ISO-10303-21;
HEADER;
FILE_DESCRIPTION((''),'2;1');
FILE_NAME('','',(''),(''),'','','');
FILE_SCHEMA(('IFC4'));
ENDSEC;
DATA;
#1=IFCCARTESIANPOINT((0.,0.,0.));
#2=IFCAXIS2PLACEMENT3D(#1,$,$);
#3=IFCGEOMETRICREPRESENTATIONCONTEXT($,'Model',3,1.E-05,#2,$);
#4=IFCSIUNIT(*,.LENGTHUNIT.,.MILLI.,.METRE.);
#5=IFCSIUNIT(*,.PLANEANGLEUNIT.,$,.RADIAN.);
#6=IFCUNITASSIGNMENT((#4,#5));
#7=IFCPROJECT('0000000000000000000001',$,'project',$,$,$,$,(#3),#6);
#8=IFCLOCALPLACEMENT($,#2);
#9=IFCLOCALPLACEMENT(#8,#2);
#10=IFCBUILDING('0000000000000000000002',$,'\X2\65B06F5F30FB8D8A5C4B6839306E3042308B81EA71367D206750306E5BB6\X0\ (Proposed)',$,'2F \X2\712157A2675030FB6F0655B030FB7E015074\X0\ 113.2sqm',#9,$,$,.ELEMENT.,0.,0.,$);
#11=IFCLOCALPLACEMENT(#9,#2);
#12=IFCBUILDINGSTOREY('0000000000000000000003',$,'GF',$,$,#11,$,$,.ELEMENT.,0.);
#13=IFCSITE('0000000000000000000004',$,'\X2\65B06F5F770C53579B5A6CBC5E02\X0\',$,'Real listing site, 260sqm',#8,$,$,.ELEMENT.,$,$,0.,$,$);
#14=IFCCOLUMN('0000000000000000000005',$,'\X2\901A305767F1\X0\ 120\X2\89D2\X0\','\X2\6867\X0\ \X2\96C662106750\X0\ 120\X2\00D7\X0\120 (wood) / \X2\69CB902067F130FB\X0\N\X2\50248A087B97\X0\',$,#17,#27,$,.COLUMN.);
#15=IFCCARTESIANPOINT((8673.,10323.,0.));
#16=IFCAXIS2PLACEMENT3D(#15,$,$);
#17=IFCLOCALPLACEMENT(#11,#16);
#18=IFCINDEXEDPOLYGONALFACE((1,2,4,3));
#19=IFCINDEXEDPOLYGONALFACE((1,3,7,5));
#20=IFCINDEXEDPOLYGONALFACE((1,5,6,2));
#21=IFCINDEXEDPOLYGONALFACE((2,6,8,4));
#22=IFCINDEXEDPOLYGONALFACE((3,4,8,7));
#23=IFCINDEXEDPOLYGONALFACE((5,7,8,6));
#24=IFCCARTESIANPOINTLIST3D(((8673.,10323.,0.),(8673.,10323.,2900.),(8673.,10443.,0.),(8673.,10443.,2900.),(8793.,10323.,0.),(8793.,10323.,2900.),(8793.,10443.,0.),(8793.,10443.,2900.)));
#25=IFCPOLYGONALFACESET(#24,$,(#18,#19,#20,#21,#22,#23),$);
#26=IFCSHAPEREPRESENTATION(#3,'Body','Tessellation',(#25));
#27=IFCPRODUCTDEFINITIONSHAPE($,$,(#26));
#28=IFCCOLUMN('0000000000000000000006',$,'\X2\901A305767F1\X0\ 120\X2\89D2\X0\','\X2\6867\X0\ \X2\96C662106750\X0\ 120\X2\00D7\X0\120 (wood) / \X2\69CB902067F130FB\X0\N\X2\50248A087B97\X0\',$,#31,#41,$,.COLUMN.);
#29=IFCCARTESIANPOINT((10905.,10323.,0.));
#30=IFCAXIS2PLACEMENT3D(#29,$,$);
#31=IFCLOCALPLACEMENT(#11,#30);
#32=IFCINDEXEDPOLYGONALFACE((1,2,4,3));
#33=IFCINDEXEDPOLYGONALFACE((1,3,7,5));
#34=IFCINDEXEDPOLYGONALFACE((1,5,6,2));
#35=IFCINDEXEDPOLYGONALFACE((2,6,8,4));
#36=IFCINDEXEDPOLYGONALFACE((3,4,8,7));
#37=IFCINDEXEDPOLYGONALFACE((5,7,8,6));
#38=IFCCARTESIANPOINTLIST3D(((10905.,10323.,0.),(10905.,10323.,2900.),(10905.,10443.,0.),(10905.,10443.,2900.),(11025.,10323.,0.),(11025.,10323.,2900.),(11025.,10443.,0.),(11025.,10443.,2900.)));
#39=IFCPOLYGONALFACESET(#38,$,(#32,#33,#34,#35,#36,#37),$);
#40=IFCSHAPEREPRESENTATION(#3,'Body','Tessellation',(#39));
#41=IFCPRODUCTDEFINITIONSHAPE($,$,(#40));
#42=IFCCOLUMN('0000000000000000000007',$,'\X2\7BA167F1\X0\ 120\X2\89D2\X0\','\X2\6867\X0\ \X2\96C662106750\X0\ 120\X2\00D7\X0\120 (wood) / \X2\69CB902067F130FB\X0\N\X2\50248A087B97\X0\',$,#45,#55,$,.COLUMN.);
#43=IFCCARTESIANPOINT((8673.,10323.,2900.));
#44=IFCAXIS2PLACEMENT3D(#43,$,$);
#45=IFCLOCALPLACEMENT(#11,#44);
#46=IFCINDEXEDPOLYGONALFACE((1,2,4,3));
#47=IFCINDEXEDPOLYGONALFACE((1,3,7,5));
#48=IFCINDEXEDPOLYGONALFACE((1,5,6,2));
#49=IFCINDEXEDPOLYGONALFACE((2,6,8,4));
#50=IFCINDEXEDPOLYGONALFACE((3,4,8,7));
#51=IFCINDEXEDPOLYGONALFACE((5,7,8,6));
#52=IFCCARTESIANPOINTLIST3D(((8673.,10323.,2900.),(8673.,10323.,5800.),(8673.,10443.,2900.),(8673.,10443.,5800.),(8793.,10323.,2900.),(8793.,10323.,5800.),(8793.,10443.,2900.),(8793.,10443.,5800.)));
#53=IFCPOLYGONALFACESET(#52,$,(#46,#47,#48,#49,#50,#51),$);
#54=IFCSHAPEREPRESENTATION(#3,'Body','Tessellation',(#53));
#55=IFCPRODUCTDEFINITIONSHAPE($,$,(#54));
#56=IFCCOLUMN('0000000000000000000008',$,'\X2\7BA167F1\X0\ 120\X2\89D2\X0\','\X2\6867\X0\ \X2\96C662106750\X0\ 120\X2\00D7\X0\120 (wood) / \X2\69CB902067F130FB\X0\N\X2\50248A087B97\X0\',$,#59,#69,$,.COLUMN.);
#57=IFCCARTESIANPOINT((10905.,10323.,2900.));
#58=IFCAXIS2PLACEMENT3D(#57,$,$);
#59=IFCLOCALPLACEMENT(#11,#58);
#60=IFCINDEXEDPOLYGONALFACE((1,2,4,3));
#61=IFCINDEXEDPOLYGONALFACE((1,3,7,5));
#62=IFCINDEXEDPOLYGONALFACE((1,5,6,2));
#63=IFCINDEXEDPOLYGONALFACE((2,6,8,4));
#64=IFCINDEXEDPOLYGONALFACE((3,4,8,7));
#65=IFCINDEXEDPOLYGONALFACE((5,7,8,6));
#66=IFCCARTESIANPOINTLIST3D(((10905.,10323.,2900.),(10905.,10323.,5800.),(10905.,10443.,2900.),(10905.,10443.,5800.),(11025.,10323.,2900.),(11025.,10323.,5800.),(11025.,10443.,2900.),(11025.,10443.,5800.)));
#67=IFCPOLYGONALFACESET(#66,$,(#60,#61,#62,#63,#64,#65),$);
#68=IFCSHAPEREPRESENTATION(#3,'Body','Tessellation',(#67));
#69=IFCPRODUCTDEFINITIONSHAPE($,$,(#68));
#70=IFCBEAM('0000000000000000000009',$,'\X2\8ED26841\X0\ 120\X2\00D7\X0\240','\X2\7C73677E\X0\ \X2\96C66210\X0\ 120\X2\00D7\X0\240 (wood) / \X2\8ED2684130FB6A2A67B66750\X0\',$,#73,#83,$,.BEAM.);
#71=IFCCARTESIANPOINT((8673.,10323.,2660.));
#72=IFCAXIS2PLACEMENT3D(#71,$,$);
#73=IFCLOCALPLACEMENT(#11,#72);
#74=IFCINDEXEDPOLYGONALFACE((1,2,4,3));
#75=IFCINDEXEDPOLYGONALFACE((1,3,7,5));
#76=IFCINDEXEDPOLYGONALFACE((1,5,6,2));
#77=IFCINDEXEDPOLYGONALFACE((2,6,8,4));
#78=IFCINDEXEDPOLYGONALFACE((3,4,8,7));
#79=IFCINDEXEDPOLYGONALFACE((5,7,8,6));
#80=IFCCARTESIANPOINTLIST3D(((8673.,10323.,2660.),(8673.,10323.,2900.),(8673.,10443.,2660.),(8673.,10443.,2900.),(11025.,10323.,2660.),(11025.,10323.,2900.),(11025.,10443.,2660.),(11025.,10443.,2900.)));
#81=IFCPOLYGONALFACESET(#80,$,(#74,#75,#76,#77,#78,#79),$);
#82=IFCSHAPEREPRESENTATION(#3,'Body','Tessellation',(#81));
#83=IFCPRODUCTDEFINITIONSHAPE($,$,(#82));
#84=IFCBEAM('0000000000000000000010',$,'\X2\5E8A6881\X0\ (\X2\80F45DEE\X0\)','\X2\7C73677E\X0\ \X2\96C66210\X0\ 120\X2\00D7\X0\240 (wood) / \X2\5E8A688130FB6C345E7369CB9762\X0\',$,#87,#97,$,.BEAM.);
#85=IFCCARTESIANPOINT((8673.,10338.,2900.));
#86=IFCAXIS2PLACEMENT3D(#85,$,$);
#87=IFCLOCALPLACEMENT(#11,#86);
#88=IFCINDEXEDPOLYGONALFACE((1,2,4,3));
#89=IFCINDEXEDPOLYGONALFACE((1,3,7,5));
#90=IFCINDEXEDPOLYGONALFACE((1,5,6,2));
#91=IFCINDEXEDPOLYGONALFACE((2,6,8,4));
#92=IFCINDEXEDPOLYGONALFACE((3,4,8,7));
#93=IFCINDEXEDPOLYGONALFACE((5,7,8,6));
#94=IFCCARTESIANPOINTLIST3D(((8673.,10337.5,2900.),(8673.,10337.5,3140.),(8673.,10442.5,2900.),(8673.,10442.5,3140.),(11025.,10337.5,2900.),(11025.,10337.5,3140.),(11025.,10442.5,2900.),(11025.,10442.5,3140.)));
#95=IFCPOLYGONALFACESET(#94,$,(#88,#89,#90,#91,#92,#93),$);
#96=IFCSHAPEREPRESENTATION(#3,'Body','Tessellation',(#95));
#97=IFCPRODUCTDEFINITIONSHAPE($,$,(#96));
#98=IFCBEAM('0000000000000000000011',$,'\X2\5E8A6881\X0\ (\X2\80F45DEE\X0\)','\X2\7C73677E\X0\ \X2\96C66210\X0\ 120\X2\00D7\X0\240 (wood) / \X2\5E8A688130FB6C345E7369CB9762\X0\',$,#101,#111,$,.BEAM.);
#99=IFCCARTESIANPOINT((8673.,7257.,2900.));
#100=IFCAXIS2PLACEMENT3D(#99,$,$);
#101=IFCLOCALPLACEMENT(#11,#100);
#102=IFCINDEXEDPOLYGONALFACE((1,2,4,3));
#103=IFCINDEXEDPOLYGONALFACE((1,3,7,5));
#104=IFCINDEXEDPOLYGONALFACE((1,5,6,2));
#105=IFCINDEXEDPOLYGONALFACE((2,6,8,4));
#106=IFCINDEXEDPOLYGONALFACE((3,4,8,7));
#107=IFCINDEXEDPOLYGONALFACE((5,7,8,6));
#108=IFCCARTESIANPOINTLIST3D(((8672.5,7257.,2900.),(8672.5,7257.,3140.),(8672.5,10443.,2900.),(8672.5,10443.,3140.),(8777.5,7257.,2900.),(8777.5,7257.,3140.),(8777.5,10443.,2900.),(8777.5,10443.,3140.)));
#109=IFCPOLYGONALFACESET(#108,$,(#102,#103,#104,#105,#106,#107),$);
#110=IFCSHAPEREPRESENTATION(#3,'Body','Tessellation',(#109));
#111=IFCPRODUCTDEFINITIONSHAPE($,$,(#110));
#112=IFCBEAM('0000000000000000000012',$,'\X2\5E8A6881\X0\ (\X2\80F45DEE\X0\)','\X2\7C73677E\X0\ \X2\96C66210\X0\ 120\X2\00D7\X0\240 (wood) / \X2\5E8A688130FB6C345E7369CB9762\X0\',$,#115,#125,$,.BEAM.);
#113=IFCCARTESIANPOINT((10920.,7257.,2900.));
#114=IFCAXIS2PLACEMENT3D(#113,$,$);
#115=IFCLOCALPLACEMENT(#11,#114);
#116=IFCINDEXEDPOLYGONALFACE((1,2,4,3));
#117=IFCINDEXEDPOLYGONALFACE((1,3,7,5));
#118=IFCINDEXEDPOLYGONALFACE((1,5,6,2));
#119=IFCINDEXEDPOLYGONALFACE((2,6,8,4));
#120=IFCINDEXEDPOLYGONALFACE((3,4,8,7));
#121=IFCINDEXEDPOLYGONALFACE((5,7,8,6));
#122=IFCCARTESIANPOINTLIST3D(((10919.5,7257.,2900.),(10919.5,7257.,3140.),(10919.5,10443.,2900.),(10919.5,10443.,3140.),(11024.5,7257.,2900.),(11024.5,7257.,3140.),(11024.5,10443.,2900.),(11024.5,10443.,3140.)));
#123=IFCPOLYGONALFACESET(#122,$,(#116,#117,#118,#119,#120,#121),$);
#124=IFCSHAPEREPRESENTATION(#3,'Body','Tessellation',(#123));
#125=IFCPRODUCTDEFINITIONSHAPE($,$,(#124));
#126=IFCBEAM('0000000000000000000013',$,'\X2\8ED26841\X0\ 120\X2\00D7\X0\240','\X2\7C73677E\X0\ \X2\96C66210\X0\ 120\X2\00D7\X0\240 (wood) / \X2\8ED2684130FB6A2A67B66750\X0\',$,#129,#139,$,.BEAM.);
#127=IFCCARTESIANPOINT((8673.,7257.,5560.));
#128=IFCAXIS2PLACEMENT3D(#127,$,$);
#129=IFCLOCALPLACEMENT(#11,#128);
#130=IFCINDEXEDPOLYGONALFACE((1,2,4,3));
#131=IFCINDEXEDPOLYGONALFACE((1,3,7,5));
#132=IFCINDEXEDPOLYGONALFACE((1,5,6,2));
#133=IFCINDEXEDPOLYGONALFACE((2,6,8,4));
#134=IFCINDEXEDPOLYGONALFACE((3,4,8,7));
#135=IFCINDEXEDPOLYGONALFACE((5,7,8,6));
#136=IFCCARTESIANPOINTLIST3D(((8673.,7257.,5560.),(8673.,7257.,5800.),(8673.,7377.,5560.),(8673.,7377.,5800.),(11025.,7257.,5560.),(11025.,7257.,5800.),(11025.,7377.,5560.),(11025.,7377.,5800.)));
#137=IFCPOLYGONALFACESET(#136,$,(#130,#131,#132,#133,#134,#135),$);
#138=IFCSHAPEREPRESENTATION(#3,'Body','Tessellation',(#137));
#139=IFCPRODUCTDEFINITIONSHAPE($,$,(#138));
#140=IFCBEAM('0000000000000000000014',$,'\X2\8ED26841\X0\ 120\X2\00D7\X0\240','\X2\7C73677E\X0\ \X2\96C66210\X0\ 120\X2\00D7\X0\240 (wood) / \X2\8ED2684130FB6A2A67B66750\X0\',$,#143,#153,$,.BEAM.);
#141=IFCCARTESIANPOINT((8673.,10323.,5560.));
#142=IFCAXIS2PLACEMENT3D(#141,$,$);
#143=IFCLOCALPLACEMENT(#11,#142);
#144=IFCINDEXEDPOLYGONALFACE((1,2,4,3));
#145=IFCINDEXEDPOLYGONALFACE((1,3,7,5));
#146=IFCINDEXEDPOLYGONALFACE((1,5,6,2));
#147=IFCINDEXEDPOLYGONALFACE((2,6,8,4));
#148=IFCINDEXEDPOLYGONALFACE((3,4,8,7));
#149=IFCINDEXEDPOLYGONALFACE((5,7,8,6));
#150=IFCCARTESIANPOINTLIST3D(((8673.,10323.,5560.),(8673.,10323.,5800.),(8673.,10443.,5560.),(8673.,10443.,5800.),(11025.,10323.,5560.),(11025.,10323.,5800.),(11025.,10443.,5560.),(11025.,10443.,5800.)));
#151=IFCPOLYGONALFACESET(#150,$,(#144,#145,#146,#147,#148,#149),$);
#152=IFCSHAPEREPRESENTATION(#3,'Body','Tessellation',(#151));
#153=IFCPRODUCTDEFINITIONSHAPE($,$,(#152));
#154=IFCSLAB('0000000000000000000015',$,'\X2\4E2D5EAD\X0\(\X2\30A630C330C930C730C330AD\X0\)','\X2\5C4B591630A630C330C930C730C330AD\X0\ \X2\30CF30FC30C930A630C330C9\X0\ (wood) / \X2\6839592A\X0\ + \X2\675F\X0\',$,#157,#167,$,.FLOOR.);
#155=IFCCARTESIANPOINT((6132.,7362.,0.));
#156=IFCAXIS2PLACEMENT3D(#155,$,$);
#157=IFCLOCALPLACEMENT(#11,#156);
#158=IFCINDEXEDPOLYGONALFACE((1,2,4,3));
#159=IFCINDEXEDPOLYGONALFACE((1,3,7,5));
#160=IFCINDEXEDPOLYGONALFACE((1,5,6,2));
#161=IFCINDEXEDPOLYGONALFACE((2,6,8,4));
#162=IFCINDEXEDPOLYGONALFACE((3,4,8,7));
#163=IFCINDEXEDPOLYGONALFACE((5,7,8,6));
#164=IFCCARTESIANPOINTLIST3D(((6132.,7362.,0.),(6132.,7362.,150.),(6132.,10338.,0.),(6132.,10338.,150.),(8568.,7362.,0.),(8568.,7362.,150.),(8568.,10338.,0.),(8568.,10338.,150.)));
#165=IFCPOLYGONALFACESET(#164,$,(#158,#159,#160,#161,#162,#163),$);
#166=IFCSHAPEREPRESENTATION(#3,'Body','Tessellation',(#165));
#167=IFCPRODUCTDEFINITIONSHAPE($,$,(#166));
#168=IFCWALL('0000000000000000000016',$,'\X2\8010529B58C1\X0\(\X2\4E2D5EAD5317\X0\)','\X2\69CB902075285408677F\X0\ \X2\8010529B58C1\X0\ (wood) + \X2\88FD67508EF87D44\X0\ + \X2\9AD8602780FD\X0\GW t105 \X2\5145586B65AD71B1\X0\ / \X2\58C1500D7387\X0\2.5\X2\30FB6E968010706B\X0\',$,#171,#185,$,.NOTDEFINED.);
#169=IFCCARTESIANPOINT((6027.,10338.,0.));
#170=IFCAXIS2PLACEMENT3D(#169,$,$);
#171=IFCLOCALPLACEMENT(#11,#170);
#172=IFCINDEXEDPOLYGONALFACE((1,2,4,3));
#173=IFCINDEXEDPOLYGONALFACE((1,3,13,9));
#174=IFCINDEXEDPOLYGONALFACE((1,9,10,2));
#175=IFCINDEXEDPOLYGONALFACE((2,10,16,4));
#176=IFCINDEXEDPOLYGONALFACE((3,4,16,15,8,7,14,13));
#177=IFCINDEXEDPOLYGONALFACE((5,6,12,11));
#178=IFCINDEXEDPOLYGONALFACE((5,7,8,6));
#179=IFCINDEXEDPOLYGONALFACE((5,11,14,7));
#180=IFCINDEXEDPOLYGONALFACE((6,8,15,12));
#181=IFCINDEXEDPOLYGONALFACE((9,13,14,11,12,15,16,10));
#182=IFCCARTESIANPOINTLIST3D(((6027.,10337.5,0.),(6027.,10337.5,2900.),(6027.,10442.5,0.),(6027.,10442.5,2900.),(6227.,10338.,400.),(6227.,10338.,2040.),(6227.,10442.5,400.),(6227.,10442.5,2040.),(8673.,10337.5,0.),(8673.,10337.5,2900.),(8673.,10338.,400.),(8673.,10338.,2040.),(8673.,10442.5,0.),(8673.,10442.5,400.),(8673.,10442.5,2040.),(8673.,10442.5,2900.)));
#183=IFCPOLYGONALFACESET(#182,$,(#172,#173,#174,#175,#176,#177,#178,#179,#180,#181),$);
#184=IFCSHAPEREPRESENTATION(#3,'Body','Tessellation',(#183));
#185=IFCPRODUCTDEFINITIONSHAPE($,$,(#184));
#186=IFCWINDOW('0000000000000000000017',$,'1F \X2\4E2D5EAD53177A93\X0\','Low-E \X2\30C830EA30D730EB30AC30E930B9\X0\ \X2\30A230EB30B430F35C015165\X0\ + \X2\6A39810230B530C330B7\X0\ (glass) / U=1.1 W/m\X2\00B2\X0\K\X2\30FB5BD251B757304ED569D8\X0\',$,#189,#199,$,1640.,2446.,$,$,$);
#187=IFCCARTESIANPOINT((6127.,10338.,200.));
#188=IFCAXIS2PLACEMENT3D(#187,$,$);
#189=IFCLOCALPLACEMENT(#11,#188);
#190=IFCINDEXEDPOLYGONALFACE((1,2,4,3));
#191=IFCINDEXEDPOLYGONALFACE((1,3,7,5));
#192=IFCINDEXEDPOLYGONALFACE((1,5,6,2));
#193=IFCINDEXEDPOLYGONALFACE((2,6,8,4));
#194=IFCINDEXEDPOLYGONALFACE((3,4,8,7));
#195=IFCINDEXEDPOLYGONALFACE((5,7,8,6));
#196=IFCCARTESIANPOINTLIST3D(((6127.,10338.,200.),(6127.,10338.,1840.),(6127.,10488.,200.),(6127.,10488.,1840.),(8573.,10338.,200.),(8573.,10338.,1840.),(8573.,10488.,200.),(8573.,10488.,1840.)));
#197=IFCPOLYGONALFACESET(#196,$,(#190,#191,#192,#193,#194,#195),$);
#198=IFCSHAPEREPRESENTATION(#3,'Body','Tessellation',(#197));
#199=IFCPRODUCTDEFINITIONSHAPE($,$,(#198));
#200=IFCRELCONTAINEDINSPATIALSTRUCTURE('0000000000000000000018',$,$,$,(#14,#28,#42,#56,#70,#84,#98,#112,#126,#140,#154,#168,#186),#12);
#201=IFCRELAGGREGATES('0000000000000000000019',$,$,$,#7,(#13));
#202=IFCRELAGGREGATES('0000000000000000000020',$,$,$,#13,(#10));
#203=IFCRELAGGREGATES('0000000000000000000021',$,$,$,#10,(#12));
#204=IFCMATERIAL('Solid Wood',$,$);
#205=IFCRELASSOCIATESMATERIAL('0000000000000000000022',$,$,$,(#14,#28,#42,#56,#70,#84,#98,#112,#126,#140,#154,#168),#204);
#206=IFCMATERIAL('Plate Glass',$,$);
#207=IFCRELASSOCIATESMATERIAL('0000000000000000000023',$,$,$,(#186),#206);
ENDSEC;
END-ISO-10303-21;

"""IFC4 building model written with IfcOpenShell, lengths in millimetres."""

from ifc_helpers import new_model, si_unit, frame, frame_2d, origin, place, context, project, spatial, rectangle, extrude, material, element, fill, save


model = new_model("IFC4")

# Units and contexts
model_context = context("Model", 3, precision=1e-05, world=origin())
ifc_project = project(units=[si_unit("LENGTHUNIT", "METRE", prefix="MILLI"), si_unit("PLANEANGLEUNIT", "RADIAN")], contexts=[model_context])

# Site, building, storey
site_placement = place(None, origin())
site = spatial("IfcSite", under=ifc_project, at=site_placement, Name="新潟県南魚沼市", ObjectType="Real listing site, 260sqm", CompositionType="ELEMENT", RefElevation=0.0)
building_placement = place(site_placement, origin())
building = spatial("IfcBuilding", under=site, at=building_placement, Name="新潟・越屋根のある自然素材の家 (Proposed)", ObjectType="2F 無垢材・漆喰・縁側 113.2sqm", CompositionType="ELEMENT", ElevationOfRefHeight=0.0, ElevationOfTerrain=0.0)
storey_placement = place(building_placement, origin())
storey = spatial("IfcBuildingStorey", under=building, at=storey_placement, Name="GF", CompositionType="ELEMENT", Elevation=0.0)

# Columns
ifc_material_1 = material(Name="Solid Wood")
column_1_placement = place(storey_placement, frame((8673.0, 10323.0, 0.0)))
element("IfcColumn", 1, at=column_1_placement, inside=storey, material=ifc_material_1, Name="通し柱 120角", Description="桧 集成材 120×120 (wood) / 構造柱・N値計算", PredefinedType="COLUMN", context=model_context, shape_type="SweptSolid", body=[
    extrude(rectangle(XDim=120.0, YDim=120.0, at=frame_2d((60.0, 60.0))), frame((8673.0, 10323.0, 0.0)), (0.0, 0.0, 1.0), 2900.0),
])
column_2_placement = place(storey_placement, frame((10905.0, 10323.0, 0.0)))
element("IfcColumn", 2, at=column_2_placement, inside=storey, material=ifc_material_1, Name="通し柱 120角", Description="桧 集成材 120×120 (wood) / 構造柱・N値計算", PredefinedType="COLUMN", context=model_context, shape_type="SweptSolid", body=[
    extrude(rectangle(XDim=120.0, YDim=120.0, at=frame_2d((60.0, 60.0))), frame((10905.0, 10323.0, 0.0)), (0.0, 0.0, 1.0), 2900.0),
])
column_3_placement = place(storey_placement, frame((8673.0, 10323.0, 2900.0)))
element("IfcColumn", 3, at=column_3_placement, inside=storey, material=ifc_material_1, Name="管柱 120角", Description="桧 集成材 120×120 (wood) / 構造柱・N値計算", PredefinedType="COLUMN", context=model_context, shape_type="SweptSolid", body=[
    extrude(rectangle(XDim=120.0, YDim=120.0, at=frame_2d((60.0, 60.0))), frame((8673.0, 10323.0, 2900.0)), (0.0, 0.0, 1.0), 2900.0),
])
column_4_placement = place(storey_placement, frame((10905.0, 10323.0, 2900.0)))
element("IfcColumn", 4, at=column_4_placement, inside=storey, material=ifc_material_1, Name="管柱 120角", Description="桧 集成材 120×120 (wood) / 構造柱・N値計算", PredefinedType="COLUMN", context=model_context, shape_type="SweptSolid", body=[
    extrude(rectangle(XDim=120.0, YDim=120.0, at=frame_2d((60.0, 60.0))), frame((10905.0, 10323.0, 2900.0)), (0.0, 0.0, 1.0), 2900.0),
])

# Beams
beam_1_placement = place(storey_placement, frame((8673.0, 10323.0, 2660.0)))
element("IfcBeam", 5, at=beam_1_placement, inside=storey, material=ifc_material_1, Name="軒桁 120×240", Description="米松 集成 120×240 (wood) / 軒桁・横架材", PredefinedType="BEAM", context=model_context, shape_type="SweptSolid", body=[
    extrude(rectangle(XDim=2352.0, YDim=120.0, at=frame_2d((1176.0, 60.0))), frame((8673.0, 10323.0, 2660.0)), (0.0, 0.0, 1.0), 240.0),
])
beam_2_placement = place(storey_placement, frame((8673.0, 10338.0, 2900.0)))
element("IfcBeam", 6, at=beam_2_placement, inside=storey, material=ifc_material_1, Name="床梁 (胴差)", Description="米松 集成 120×240 (wood) / 床梁・水平構面", PredefinedType="BEAM", context=model_context, shape_type="SweptSolid", body=[
    extrude(rectangle(XDim=2352.0, YDim=105.0, at=frame_2d((1176.0, 52.0))), frame((8673.0, 10338.0, 2900.0)), (0.0, 0.0, 1.0), 240.0),
])
beam_3_placement = place(storey_placement, frame((8673.0, 7257.0, 2900.0)))
element("IfcBeam", 7, at=beam_3_placement, inside=storey, material=ifc_material_1, Name="床梁 (胴差)", Description="米松 集成 120×240 (wood) / 床梁・水平構面", PredefinedType="BEAM", context=model_context, shape_type="SweptSolid", body=[
    extrude(rectangle(XDim=105.0, YDim=3186.0, at=frame_2d((52.0, 1593.0))), frame((8673.0, 7257.0, 2900.0)), (0.0, 0.0, 1.0), 240.0),
])
beam_4_placement = place(storey_placement, frame((10920.0, 7257.0, 2900.0)))
element("IfcBeam", 8, at=beam_4_placement, inside=storey, material=ifc_material_1, Name="床梁 (胴差)", Description="米松 集成 120×240 (wood) / 床梁・水平構面", PredefinedType="BEAM", context=model_context, shape_type="SweptSolid", body=[
    extrude(rectangle(XDim=105.0, YDim=3186.0, at=frame_2d((52.0, 1593.0))), frame((10920.0, 7257.0, 2900.0)), (0.0, 0.0, 1.0), 240.0),
])
beam_5_placement = place(storey_placement, frame((8673.0, 7257.0, 5560.0)))
element("IfcBeam", 9, at=beam_5_placement, inside=storey, material=ifc_material_1, Name="軒桁 120×240", Description="米松 集成 120×240 (wood) / 軒桁・横架材", PredefinedType="BEAM", context=model_context, shape_type="SweptSolid", body=[
    extrude(rectangle(XDim=2352.0, YDim=120.0, at=frame_2d((1176.0, 60.0))), frame((8673.0, 7257.0, 5560.0)), (0.0, 0.0, 1.0), 240.0),
])
beam_6_placement = place(storey_placement, frame((8673.0, 10323.0, 5560.0)))
element("IfcBeam", 10, at=beam_6_placement, inside=storey, material=ifc_material_1, Name="軒桁 120×240", Description="米松 集成 120×240 (wood) / 軒桁・横架材", PredefinedType="BEAM", context=model_context, shape_type="SweptSolid", body=[
    extrude(rectangle(XDim=2352.0, YDim=120.0, at=frame_2d((1176.0, 60.0))), frame((8673.0, 10323.0, 5560.0)), (0.0, 0.0, 1.0), 240.0),
])

# Slab
slab_placement = place(storey_placement, frame((6132.0, 7362.0, 0.0)))
element("IfcSlab", 11, at=slab_placement, inside=storey, material=ifc_material_1, Name="中庭(ウッドデッキ)", Description="屋外ウッドデッキ ハードウッド (wood) / 根太 + 束", PredefinedType="FLOOR", context=model_context, shape_type="SweptSolid", body=[
    extrude(rectangle(XDim=2436.0, YDim=2976.0, at=frame_2d((1218.0, 1488.0))), frame((6132.0, 7362.0, 0.0)), (0.0, 0.0, 1.0), 150.0),
])

# Wall, opening, window
wall_1_placement = place(storey_placement, frame((6027.0, 10338.0, 0.0)))
wall_1 = element("IfcWall", 12, at=wall_1_placement, inside=storey, material=ifc_material_1, Name="耐力壁(中庭北)", Description="構造用合板 耐力壁 (wood) + 製材軸組 + 高性能GW t105 充填断熱 / 壁倍率2.5・準耐火", PredefinedType="NOTDEFINED", context=model_context, shape_type="SweptSolid", body=[
    extrude(rectangle(XDim=2646.0, YDim=105.0, at=frame_2d((1323.0, 52.0))), frame((6027.0, 10338.0, 0.0)), (0.0, 0.0, 1.0), 2900.0),
])
opening_1_placement = place(storey_placement, frame((6127.0, 10338.0, 200.0)))
opening_1 = element("IfcOpeningElement", 13, at=opening_1_placement, cuts=wall_1, PredefinedType="NOTDEFINED", context=model_context, shape_type="SweptSolid", body=[
    extrude(rectangle(XDim=2446.0, YDim=150.0, at=frame_2d((1223.0, 75.0))), frame((6127.0, 10338.0, 200.0)), (0.0, 0.0, 1.0), 1640.0),
])
ifc_material_2 = material(Name="Plate Glass")
window_1_placement = place(storey_placement, frame((6127.0, 10338.0, 200.0)))
window_1 = element("IfcWindow", 14, at=window_1_placement, inside=storey, material=ifc_material_2, Name="1F 中庭北窓", Description="Low-E トリプルガラス アルゴン封入 + 樹脂サッシ (glass) / U=1.1 W/m²K・寒冷地仕様", OverallHeight=1640.0, OverallWidth=2446.0, context=model_context, shape_type="SweptSolid", body=[
    extrude(rectangle(XDim=2446.0, YDim=150.0, at=frame_2d((1223.0, 75.0))), frame((6127.0, 10338.0, 200.0)), (0.0, 0.0, 1.0), 1640.0),
])
fill(opening_1, window_1)

save(model, "model.ifc")
